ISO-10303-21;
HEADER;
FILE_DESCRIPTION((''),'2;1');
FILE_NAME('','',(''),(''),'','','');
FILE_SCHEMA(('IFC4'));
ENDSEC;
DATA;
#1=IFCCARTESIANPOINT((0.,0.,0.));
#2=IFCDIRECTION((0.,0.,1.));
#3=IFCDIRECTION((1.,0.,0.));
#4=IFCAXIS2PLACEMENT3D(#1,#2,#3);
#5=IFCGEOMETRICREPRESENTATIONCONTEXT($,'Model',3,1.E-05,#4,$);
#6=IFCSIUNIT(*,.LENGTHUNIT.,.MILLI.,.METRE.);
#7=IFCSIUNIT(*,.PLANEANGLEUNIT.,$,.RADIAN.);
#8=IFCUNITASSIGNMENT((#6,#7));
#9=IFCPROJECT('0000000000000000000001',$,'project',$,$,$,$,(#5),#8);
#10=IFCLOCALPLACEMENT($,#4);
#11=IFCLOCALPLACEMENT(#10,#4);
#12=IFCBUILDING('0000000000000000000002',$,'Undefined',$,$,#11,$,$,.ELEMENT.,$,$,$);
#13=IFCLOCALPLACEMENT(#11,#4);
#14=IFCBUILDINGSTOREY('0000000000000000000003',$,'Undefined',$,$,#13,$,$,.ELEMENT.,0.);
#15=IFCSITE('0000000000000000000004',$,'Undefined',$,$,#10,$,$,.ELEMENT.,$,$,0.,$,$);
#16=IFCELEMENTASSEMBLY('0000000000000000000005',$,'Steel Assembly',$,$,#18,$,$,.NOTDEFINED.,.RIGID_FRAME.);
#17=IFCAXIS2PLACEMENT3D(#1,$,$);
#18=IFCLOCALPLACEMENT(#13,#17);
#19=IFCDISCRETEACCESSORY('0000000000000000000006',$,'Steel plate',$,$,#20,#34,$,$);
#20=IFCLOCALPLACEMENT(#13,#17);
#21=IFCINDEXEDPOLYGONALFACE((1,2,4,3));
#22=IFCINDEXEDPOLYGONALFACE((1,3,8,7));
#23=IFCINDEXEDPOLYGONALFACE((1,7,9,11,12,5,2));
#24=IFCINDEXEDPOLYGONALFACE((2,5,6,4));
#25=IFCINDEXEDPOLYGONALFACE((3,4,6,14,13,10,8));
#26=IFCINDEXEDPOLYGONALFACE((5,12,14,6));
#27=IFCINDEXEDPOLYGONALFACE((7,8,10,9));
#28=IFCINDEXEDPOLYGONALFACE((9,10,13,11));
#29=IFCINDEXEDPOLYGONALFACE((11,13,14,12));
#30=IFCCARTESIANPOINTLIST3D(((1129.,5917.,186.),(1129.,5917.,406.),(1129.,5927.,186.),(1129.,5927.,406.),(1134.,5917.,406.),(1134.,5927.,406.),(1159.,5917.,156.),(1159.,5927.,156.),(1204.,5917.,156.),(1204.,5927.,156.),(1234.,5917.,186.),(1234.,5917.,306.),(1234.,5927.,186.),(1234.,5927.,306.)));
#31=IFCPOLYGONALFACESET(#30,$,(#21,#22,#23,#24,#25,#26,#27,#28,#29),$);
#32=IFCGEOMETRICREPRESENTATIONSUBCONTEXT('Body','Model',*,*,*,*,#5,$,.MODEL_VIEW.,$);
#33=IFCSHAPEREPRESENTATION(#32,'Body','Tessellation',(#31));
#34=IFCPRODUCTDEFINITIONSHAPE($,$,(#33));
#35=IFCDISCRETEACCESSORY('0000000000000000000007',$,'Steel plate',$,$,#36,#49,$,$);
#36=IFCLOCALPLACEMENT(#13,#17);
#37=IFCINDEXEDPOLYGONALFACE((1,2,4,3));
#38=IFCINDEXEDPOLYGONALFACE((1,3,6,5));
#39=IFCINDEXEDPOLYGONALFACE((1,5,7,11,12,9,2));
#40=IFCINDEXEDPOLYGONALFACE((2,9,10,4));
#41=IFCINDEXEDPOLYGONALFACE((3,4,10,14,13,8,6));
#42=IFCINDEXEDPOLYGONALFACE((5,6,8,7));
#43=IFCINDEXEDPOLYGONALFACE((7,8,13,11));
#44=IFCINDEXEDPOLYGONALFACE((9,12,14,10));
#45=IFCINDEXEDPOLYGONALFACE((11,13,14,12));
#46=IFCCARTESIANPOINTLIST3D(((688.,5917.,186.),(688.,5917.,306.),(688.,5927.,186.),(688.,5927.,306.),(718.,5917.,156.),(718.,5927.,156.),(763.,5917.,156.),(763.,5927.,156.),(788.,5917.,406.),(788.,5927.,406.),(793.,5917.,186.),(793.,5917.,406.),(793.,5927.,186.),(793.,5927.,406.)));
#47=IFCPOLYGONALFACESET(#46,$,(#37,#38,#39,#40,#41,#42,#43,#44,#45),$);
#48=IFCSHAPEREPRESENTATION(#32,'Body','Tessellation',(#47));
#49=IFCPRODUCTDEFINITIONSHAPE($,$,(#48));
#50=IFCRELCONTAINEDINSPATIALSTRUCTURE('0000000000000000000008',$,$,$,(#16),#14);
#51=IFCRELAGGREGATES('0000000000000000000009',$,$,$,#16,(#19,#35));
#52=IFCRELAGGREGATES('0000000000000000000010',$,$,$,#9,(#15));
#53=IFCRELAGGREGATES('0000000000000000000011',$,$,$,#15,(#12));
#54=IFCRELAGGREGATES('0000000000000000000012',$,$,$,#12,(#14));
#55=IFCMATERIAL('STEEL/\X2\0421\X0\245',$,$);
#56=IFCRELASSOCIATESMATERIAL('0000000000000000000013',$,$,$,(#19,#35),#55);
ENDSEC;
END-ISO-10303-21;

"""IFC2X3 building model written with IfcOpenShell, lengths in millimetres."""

from ifc_helpers import new_model, si_unit, frame, origin_with_axes, place, context, subcontext, project, spatial, polyline, outline, extrude, material, element, aggregate, save


model = new_model("IFC2X3")

# Units and contexts
model_context = context("Model", 3, precision=1e-05, world=origin_with_axes())
body_context = subcontext(model_context, "Body", "Model", "MODEL_VIEW")
ifc_project = project(units=[si_unit("LENGTHUNIT", "METRE", prefix="MILLI"), si_unit("PLANEANGLEUNIT", "RADIAN")], contexts=[model_context])

# Site, building, storey
site_placement = place(None, origin_with_axes())
site = spatial("IfcSite", under=ifc_project, at=site_placement, Name="Undefined", CompositionType="ELEMENT", RefElevation=0.0)
building_placement = place(site_placement, origin_with_axes())
building = spatial("IfcBuilding", under=site, at=building_placement, Name="Undefined", CompositionType="ELEMENT")
storey_placement = place(building_placement, origin_with_axes())
storey = spatial("IfcBuildingStorey", under=building, at=storey_placement, Name="Undefined", CompositionType="ELEMENT", Elevation=0.0)

# Shared definitions
ifc_material_1 = material(Name="STEEL/С245")

# Element assembly, discrete accessories
assembly_1_placement = place(storey_placement, origin_with_axes())
assembly_1 = element("IfcElementAssembly", 1, at=assembly_1_placement, inside=storey, Name="Steel Assembly", AssemblyPlace="NOTDEFINED", PredefinedType="RIGID_FRAME")
discrete_accessory_1_placement = place(assembly_1_placement, frame((1129.0, 5922.0, 156.0), z_axis=(0.0, -1.0, 0.0), x_axis=(1.0, 0.0, 0.0)))
discrete_accessory_1 = element("IfcDiscreteAccessory", 2, at=discrete_accessory_1_placement, material=ifc_material_1, Name="Steel plate", context=body_context, shape_type="SweptSolid", body=[
    extrude(outline(polyline([(0.0, 30.0), (30.0, 0.0), (75.0, 0.0), (105.0, 30.0), (105.0, 150.0), (5.0, 250.0), (0.0, 250.0), (0.0, 30.0)])), frame((0.0, 0.0, -5.0), z_axis=(0.0, 0.0, 1.0), x_axis=(1.0, 0.0, 0.0)), (0.0, 0.0, 1.0), 10.0),
])
discrete_accessory_2_placement = place(assembly_1_placement, frame((793.0, 5922.0, 156.0), z_axis=(0.0, 1.0, 0.0), x_axis=(-1.0, 0.0, 0.0)))
discrete_accessory_2 = element("IfcDiscreteAccessory", 3, at=discrete_accessory_2_placement, material=ifc_material_1, Name="Steel plate", context=body_context, shape_type="SweptSolid", body=[
    extrude(outline(polyline([(0.0, 30.0), (30.0, 0.0), (75.0, 0.0), (105.0, 30.0), (105.0, 150.0), (5.0, 250.0), (0.0, 250.0), (0.0, 30.0)])), frame((0.0, 0.0, -5.0), z_axis=(0.0, 0.0, 1.0), x_axis=(1.0, 0.0, 0.0)), (0.0, 0.0, 1.0), 10.0),
])
aggregate(assembly_1, [discrete_accessory_1, discrete_accessory_2])

save(model, "model.ifc")
